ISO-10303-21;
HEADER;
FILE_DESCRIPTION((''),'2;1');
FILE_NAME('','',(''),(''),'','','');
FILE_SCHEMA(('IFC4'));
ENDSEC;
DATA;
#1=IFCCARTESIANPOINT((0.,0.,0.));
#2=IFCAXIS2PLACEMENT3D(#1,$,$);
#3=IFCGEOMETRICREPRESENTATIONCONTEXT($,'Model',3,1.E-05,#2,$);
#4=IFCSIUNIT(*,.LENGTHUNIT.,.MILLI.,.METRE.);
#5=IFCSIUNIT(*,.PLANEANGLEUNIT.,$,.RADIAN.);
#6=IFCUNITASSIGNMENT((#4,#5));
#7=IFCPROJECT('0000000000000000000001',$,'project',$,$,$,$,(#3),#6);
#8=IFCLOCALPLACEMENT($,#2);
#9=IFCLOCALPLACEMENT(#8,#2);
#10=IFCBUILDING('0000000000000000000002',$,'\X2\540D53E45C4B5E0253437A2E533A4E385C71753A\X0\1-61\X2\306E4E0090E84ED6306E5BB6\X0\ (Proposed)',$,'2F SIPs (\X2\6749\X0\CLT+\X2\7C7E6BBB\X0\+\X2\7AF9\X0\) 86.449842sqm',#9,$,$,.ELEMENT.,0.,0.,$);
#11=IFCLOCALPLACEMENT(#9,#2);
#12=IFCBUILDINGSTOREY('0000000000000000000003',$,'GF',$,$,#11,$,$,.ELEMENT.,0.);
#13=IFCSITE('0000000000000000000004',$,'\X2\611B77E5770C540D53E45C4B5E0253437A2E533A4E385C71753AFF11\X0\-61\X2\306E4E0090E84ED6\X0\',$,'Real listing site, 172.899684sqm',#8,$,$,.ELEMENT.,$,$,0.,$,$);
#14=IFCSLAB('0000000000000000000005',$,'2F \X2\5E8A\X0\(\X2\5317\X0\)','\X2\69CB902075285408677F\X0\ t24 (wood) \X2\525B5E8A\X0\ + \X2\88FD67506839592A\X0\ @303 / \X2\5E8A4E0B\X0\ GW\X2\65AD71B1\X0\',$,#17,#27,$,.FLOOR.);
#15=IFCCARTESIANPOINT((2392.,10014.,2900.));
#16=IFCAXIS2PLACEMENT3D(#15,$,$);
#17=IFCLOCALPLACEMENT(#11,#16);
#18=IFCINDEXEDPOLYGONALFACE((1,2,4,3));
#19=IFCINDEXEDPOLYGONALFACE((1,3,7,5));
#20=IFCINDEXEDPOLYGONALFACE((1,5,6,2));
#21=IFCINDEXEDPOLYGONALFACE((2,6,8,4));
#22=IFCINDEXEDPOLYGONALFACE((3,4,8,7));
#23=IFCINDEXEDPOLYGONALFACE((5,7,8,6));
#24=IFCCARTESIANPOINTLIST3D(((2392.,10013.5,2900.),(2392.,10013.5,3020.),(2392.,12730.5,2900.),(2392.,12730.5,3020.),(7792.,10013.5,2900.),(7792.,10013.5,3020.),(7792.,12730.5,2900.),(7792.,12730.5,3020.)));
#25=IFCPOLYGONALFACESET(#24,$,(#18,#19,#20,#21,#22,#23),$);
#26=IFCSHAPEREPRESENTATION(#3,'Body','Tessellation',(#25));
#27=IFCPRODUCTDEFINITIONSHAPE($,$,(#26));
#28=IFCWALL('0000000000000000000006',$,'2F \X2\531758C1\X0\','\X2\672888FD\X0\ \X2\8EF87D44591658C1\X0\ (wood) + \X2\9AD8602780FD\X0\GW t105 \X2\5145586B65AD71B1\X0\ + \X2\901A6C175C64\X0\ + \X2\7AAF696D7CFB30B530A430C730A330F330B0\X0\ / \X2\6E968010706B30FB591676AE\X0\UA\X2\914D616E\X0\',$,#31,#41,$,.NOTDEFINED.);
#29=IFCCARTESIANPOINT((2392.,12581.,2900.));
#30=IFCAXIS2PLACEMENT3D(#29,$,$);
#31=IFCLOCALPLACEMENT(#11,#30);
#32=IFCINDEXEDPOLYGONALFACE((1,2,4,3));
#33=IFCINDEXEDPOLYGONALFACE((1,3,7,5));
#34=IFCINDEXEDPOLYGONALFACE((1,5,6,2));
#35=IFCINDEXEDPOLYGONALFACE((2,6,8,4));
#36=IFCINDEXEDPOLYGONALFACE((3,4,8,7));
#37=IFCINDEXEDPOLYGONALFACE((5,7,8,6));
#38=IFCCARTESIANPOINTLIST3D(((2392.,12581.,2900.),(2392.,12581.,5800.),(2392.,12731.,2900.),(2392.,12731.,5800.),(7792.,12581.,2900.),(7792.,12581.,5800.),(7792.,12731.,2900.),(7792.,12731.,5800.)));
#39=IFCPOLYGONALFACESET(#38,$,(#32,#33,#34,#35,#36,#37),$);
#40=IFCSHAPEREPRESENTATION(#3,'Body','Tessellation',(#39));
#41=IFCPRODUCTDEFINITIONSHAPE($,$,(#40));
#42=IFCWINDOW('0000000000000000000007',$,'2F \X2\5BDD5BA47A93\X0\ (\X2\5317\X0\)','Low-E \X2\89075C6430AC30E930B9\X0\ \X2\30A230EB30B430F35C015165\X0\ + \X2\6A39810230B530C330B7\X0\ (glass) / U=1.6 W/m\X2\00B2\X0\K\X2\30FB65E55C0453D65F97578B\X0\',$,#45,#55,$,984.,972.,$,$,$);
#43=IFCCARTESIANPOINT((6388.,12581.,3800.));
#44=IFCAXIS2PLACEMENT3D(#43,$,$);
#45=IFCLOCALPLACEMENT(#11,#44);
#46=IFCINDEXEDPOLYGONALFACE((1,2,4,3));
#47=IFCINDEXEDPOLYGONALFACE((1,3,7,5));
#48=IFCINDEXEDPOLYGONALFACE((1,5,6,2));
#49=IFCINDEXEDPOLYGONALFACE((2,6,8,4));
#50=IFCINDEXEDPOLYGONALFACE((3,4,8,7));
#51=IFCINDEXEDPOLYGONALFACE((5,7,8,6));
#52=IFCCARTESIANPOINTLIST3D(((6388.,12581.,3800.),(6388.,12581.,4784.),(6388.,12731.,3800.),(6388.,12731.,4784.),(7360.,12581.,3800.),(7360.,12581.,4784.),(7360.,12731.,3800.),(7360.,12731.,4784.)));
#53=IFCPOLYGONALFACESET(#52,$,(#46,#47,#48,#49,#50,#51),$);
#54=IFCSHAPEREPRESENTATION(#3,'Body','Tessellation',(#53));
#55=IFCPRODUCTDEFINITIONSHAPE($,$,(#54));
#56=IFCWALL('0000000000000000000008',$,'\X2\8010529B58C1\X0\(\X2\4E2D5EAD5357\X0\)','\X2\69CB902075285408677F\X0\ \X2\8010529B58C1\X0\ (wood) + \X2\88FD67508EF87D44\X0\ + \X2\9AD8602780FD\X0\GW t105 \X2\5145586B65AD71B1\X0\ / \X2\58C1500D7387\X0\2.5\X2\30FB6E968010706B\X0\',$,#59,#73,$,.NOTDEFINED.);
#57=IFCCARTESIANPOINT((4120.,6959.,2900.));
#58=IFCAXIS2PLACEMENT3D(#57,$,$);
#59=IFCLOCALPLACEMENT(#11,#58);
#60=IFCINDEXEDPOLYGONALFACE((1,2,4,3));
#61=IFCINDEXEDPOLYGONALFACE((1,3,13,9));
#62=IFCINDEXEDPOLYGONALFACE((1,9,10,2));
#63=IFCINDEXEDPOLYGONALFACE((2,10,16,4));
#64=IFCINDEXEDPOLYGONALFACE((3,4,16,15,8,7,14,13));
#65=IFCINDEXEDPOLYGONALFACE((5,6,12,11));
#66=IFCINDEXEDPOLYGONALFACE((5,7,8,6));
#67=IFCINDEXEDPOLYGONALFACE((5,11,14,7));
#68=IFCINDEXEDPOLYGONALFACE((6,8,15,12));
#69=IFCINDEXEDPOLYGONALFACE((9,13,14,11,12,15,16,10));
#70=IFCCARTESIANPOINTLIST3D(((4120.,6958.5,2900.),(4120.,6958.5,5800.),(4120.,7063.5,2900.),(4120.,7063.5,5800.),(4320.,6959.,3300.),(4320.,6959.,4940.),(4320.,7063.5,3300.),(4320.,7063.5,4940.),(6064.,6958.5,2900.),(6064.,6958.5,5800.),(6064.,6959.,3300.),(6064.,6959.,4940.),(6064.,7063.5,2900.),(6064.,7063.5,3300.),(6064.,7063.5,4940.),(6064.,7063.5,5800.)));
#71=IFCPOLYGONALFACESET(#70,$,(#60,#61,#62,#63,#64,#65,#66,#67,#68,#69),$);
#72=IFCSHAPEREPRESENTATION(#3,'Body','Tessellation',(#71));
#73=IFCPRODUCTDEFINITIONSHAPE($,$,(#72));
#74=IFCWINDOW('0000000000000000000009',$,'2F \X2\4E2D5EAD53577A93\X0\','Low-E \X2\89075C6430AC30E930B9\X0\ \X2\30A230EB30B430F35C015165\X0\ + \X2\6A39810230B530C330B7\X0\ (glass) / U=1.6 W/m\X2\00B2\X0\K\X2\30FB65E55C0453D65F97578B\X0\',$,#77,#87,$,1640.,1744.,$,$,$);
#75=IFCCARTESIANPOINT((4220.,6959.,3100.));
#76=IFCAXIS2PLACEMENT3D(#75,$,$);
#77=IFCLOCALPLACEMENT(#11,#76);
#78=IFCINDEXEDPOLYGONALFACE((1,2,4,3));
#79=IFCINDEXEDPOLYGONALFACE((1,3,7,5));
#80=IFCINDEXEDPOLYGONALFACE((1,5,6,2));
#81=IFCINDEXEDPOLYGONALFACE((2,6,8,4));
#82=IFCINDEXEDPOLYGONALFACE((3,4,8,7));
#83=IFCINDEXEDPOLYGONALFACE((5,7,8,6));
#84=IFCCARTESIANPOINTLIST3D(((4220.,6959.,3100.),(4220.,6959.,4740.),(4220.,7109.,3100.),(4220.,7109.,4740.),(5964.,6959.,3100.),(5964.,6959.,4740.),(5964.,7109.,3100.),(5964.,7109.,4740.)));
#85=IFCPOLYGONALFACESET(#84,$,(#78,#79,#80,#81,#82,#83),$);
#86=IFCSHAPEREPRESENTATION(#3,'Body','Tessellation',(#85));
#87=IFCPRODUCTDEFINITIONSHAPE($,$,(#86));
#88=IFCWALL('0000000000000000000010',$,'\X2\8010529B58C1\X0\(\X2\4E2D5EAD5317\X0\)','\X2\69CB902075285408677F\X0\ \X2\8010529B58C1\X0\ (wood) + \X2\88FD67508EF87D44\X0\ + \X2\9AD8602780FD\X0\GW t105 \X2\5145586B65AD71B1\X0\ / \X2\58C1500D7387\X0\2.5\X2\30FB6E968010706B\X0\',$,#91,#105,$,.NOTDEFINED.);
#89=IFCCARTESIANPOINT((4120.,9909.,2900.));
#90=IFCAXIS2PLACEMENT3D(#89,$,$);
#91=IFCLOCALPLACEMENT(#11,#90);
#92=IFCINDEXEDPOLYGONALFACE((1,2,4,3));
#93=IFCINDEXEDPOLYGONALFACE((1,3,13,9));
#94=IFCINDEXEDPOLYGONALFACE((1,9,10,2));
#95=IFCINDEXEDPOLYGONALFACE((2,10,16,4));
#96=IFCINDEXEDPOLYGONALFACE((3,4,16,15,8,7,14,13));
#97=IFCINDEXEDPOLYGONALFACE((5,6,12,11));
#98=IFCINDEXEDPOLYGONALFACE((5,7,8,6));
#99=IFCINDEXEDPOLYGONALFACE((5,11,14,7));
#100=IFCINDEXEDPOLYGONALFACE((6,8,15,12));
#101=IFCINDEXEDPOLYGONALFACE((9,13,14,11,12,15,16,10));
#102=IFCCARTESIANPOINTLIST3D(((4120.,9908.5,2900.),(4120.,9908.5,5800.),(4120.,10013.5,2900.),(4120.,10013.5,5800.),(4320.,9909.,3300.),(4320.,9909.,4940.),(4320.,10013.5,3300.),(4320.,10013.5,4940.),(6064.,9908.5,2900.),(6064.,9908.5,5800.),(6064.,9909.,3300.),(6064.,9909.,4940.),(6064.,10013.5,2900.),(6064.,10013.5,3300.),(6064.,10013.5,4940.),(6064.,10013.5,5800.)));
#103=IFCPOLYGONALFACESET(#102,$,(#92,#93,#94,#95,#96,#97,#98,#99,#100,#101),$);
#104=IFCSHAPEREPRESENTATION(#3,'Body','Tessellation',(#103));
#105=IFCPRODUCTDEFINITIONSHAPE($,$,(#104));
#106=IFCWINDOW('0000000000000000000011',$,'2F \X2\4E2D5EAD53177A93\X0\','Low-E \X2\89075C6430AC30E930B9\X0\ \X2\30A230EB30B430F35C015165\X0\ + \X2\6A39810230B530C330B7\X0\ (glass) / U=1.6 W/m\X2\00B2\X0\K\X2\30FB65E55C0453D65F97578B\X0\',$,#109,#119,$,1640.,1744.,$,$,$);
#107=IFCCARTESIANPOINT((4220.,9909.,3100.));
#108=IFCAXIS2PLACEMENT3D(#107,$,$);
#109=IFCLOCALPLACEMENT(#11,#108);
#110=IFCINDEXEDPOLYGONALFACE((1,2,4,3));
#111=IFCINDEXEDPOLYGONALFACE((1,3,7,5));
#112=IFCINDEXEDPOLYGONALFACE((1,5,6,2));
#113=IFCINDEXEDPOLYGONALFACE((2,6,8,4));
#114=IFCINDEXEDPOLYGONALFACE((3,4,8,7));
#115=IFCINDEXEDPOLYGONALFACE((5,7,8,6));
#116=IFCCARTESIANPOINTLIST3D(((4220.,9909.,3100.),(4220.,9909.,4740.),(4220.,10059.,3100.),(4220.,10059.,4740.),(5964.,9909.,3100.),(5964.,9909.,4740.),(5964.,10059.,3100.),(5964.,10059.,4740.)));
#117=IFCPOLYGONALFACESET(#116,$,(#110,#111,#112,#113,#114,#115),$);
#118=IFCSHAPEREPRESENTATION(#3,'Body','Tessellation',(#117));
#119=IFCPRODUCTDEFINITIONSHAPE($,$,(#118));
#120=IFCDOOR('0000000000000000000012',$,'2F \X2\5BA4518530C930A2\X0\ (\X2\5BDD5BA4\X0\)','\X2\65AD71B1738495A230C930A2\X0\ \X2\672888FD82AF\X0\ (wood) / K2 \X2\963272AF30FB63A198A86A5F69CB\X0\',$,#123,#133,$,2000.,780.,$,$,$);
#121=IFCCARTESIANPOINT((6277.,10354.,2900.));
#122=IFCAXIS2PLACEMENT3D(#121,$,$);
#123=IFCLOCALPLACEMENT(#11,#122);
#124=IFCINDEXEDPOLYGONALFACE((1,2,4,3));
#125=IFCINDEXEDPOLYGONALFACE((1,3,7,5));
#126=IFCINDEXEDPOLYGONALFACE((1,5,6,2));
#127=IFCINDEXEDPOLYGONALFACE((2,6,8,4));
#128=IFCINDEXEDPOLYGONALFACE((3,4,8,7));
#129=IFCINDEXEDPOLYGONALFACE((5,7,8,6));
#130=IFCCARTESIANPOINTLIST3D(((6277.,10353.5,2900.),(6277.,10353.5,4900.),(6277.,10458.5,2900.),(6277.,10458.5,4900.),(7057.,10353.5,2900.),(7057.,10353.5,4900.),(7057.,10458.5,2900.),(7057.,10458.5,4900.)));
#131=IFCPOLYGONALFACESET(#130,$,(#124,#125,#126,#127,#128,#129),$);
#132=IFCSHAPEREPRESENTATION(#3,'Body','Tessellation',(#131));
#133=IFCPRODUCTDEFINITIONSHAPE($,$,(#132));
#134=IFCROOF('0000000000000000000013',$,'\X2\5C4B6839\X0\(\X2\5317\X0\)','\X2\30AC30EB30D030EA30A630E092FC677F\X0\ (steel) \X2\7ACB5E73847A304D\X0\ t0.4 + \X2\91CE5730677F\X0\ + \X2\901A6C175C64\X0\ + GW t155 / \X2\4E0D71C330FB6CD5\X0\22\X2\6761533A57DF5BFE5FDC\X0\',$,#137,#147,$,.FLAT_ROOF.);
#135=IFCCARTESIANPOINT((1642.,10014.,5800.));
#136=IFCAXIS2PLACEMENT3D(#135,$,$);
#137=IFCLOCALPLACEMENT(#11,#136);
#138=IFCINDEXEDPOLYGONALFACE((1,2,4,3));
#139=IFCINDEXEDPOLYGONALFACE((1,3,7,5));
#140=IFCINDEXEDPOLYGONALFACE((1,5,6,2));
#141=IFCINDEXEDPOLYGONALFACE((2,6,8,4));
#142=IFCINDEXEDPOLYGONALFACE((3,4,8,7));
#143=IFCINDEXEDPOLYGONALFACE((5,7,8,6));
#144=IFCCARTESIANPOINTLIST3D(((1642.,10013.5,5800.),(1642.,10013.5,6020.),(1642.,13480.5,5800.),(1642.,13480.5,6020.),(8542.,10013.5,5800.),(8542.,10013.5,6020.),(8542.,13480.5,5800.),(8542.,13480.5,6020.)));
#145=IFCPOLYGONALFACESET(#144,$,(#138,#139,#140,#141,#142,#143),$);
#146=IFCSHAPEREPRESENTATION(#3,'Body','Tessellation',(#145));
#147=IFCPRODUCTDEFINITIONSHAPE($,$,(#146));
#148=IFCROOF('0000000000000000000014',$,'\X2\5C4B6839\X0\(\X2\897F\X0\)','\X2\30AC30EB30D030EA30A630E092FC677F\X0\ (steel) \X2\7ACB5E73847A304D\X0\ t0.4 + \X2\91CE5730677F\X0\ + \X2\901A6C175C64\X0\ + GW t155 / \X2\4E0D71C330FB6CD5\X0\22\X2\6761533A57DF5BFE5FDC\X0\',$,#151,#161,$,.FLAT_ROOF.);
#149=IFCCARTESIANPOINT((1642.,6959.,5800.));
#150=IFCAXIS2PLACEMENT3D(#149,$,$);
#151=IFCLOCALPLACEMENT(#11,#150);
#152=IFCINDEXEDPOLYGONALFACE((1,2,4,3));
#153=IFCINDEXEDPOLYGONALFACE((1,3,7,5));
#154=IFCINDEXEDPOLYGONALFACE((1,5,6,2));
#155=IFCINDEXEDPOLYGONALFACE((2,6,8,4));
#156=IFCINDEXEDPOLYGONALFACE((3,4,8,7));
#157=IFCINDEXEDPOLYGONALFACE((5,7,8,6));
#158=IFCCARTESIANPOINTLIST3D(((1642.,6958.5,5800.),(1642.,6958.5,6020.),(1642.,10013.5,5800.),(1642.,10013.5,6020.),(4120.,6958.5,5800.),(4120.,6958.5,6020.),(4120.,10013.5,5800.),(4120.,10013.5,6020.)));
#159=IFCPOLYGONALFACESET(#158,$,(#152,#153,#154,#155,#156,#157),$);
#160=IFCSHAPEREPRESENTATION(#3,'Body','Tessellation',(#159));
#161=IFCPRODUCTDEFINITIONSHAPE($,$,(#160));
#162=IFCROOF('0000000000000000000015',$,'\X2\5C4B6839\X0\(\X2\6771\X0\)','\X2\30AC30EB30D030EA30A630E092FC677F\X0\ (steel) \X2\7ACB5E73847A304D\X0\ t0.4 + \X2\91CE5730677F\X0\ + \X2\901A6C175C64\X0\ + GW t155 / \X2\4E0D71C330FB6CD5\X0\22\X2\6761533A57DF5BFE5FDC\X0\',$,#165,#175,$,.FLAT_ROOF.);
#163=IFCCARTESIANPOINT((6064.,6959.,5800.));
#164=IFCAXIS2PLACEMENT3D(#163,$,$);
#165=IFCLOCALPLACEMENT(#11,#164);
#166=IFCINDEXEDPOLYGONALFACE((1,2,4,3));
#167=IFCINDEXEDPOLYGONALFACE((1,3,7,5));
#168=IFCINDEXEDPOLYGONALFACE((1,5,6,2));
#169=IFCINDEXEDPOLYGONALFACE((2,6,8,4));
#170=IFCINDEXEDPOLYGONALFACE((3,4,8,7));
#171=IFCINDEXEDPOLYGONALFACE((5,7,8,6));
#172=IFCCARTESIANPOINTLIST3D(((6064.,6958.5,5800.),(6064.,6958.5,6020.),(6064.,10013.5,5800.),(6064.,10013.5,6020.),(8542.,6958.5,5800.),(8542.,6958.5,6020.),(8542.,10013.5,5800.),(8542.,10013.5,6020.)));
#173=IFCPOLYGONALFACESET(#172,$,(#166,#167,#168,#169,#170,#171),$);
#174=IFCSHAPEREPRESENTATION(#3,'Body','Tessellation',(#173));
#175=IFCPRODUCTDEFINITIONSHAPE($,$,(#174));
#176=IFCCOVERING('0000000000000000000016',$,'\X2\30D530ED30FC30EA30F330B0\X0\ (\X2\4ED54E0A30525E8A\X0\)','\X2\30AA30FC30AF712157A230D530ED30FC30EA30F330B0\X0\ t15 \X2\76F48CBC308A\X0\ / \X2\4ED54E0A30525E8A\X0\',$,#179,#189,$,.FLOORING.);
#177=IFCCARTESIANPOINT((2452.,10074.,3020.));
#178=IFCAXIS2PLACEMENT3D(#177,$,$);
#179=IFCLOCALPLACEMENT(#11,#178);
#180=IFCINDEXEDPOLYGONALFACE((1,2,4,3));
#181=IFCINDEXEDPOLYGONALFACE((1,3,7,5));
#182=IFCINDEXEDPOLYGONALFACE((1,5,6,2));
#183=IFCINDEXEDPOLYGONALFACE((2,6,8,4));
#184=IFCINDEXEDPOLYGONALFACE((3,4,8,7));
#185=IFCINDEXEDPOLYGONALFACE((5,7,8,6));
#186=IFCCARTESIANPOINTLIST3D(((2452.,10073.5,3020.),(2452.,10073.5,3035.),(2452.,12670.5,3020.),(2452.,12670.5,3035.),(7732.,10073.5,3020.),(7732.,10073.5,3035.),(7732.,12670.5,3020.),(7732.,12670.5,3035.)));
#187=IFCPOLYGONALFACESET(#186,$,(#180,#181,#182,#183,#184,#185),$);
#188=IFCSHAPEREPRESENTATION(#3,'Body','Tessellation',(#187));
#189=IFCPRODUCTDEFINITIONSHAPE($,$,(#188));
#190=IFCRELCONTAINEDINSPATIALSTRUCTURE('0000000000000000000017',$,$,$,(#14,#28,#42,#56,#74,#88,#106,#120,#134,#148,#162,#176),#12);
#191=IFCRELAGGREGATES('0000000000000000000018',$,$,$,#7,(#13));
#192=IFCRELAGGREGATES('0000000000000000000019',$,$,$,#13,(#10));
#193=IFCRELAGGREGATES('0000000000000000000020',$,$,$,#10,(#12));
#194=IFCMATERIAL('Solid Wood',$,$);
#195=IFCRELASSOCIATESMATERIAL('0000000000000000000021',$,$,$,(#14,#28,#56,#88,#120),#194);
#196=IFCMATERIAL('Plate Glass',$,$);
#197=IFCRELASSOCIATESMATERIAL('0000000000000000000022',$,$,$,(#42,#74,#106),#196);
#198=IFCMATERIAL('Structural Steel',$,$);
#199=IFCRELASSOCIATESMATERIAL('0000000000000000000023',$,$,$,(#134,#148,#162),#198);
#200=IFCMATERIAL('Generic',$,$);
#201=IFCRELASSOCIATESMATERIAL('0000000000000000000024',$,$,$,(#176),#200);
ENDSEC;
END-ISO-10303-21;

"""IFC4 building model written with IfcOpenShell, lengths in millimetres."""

from ifc_helpers import new_model, si_unit, frame, frame_2d, origin, place, context, project, spatial, rectangle, extrude, material, element, fill, save


model = new_model("IFC4")

# Units and contexts
model_context = context("Model", 3, precision=1e-05, world=origin())
ifc_project = project(units=[si_unit("LENGTHUNIT", "METRE", prefix="MILLI"), si_unit("PLANEANGLEUNIT", "RADIAN")], contexts=[model_context])

# Site, building, storey
site_placement = place(None, origin())
site = spatial("IfcSite", under=ifc_project, at=site_placement, Name="愛知県名古屋市千種区丸山町１-61の一部他", ObjectType="Real listing site, 172.899684sqm", CompositionType="ELEMENT", RefElevation=0.0)
building_placement = place(site_placement, origin())
building = spatial("IfcBuilding", under=site, at=building_placement, Name="名古屋市千種区丸山町1-61の一部他の家 (Proposed)", ObjectType="2F SIPs (杉CLT+籾殻+竹) 86.449842sqm", CompositionType="ELEMENT", ElevationOfRefHeight=0.0, ElevationOfTerrain=0.0)
storey_placement = place(building_placement, origin())
storey = spatial("IfcBuildingStorey", under=building, at=storey_placement, Name="GF", CompositionType="ELEMENT", Elevation=0.0)

# Slab
ifc_material_1 = material(Name="Solid Wood")
slab_placement = place(storey_placement, frame((2392.0, 10014.0, 2900.0)))
element("IfcSlab", 1, at=slab_placement, inside=storey, material=ifc_material_1, Name="2F 床(北)", Description="構造用合板 t24 (wood) 剛床 + 製材根太 @303 / 床下 GW断熱", PredefinedType="FLOOR", context=model_context, shape_type="SweptSolid", body=[
    extrude(rectangle(XDim=5400.0, YDim=2717.0, at=frame_2d((2700.0, 1358.0))), frame((2392.0, 10014.0, 2900.0)), (0.0, 0.0, 1.0), 120.0),
])

# Walls, openings, windows
wall_1_placement = place(storey_placement, frame((2392.0, 12581.0, 2900.0)))
wall_1 = element("IfcWall", 2, at=wall_1_placement, inside=storey, material=ifc_material_1, Name="2F 北壁", Description="木製 軸組外壁 (wood) + 高性能GW t105 充填断熱 + 通気層 + 窯業系サイディング / 準耐火・外皮UA配慮", PredefinedType="NOTDEFINED", context=model_context, shape_type="SweptSolid", body=[
    extrude(rectangle(XDim=5400.0, YDim=150.0, at=frame_2d((2700.0, 75.0))), frame((2392.0, 12581.0, 2900.0)), (0.0, 0.0, 1.0), 2900.0),
])
opening_1_placement = place(storey_placement, frame((6388.0, 12581.0, 3800.0)))
opening_1 = element("IfcOpeningElement", 3, at=opening_1_placement, cuts=wall_1, PredefinedType="NOTDEFINED", context=model_context, shape_type="SweptSolid", body=[
    extrude(rectangle(XDim=972.0, YDim=150.0, at=frame_2d((486.0, 75.0))), frame((6388.0, 12581.0, 3800.0)), (0.0, 0.0, 1.0), 984.0),
])
ifc_material_2 = material(Name="Plate Glass")
window_1_placement = place(storey_placement, frame((6388.0, 12581.0, 3800.0)))
window_1 = element("IfcWindow", 4, at=window_1_placement, inside=storey, material=ifc_material_2, Name="2F 寝室窓 (北)", Description="Low-E 複層ガラス アルゴン封入 + 樹脂サッシ (glass) / U=1.6 W/m²K・日射取得型", OverallHeight=984.0, OverallWidth=972.0, context=model_context, shape_type="SweptSolid", body=[
    extrude(rectangle(XDim=972.0, YDim=150.0, at=frame_2d((486.0, 75.0))), frame((6388.0, 12581.0, 3800.0)), (0.0, 0.0, 1.0), 984.0),
])
fill(opening_1, window_1)
wall_2_placement = place(storey_placement, frame((4120.0, 6959.0, 2900.0)))
wall_2 = element("IfcWall", 5, at=wall_2_placement, inside=storey, material=ifc_material_1, Name="耐力壁(中庭南)", Description="構造用合板 耐力壁 (wood) + 製材軸組 + 高性能GW t105 充填断熱 / 壁倍率2.5・準耐火", PredefinedType="NOTDEFINED", context=model_context, shape_type="SweptSolid", body=[
    extrude(rectangle(XDim=1944.0, YDim=105.0, at=frame_2d((972.0, 52.0))), frame((4120.0, 6959.0, 2900.0)), (0.0, 0.0, 1.0), 2900.0),
])
opening_2_placement = place(storey_placement, frame((4220.0, 6959.0, 3100.0)))
opening_2 = element("IfcOpeningElement", 6, at=opening_2_placement, cuts=wall_2, PredefinedType="NOTDEFINED", context=model_context, shape_type="SweptSolid", body=[
    extrude(rectangle(XDim=1744.0, YDim=150.0, at=frame_2d((872.0, 75.0))), frame((4220.0, 6959.0, 3100.0)), (0.0, 0.0, 1.0), 1640.0),
])
window_2_placement = place(storey_placement, frame((4220.0, 6959.0, 3100.0)))
window_2 = element("IfcWindow", 7, at=window_2_placement, inside=storey, material=ifc_material_2, Name="2F 中庭南窓", Description="Low-E 複層ガラス アルゴン封入 + 樹脂サッシ (glass) / U=1.6 W/m²K・日射取得型", OverallHeight=1640.0, OverallWidth=1744.0, context=model_context, shape_type="SweptSolid", body=[
    extrude(rectangle(XDim=1744.0, YDim=150.0, at=frame_2d((872.0, 75.0))), frame((4220.0, 6959.0, 3100.0)), (0.0, 0.0, 1.0), 1640.0),
])
fill(opening_2, window_2)
wall_3_placement = place(storey_placement, frame((4120.0, 9909.0, 2900.0)))
wall_3 = element("IfcWall", 8, at=wall_3_placement, inside=storey, material=ifc_material_1, Name="耐力壁(中庭北)", Description="構造用合板 耐力壁 (wood) + 製材軸組 + 高性能GW t105 充填断熱 / 壁倍率2.5・準耐火", PredefinedType="NOTDEFINED", context=model_context, shape_type="SweptSolid", body=[
    extrude(rectangle(XDim=1944.0, YDim=105.0, at=frame_2d((972.0, 52.0))), frame((4120.0, 9909.0, 2900.0)), (0.0, 0.0, 1.0), 2900.0),
])
opening_3_placement = place(storey_placement, frame((4220.0, 9909.0, 3100.0)))
opening_3 = element("IfcOpeningElement", 9, at=opening_3_placement, cuts=wall_3, PredefinedType="NOTDEFINED", context=model_context, shape_type="SweptSolid", body=[
    extrude(rectangle(XDim=1744.0, YDim=150.0, at=frame_2d((872.0, 75.0))), frame((4220.0, 9909.0, 3100.0)), (0.0, 0.0, 1.0), 1640.0),
])
window_3_placement = place(storey_placement, frame((4220.0, 9909.0, 3100.0)))
window_3 = element("IfcWindow", 10, at=window_3_placement, inside=storey, material=ifc_material_2, Name="2F 中庭北窓", Description="Low-E 複層ガラス アルゴン封入 + 樹脂サッシ (glass) / U=1.6 W/m²K・日射取得型", OverallHeight=1640.0, OverallWidth=1744.0, context=model_context, shape_type="SweptSolid", body=[
    extrude(rectangle(XDim=1744.0, YDim=150.0, at=frame_2d((872.0, 75.0))), frame((4220.0, 9909.0, 3100.0)), (0.0, 0.0, 1.0), 1640.0),
])
fill(opening_3, window_3)

# Door
door_placement = place(storey_placement, frame((6277.0, 10354.0, 2900.0)))
element("IfcDoor", 11, at=door_placement, inside=storey, material=ifc_material_1, Name="2F 室内ドア (寝室)", Description="断熱玄関ドア 木製芯 (wood) / K2 防犯・採風機構", OverallHeight=2000.0, OverallWidth=780.0, context=model_context, shape_type="SweptSolid", body=[
    extrude(rectangle(XDim=780.0, YDim=105.0, at=frame_2d((390.0, 52.0))), frame((6277.0, 10354.0, 2900.0)), (0.0, 0.0, 1.0), 2000.0),
])

# Roofs
ifc_material_3 = material(Name="Structural Steel")
for number, where, name in (
    (12, (1642.0, 10014.0, 5800.0), "屋根(北)"),
):
    element("IfcRoof", number, at=place(storey_placement, frame(where)), inside=storey, material=ifc_material_3, Name=name, Description="ガルバリウム鋼板 (steel) 立平葺き t0.4 + 野地板 + 通気層 + GW t155 / 不燃・法22条区域対応", PredefinedType="FLAT_ROOF", context=model_context, shape_type="SweptSolid", body=[
        extrude(rectangle(XDim=6900.0, YDim=3467.0, at=frame_2d((3450.0, 1733.0))), frame((1642.0, 10014.0, 5800.0)), (0.0, 0.0, 1.0), 220.0),
    ])
roof_1_placement = place(storey_placement, frame((1642.0, 6959.0, 5800.0)))
element("IfcRoof", 13, at=roof_1_placement, inside=storey, material=ifc_material_3, Name="屋根(西)", Description="ガルバリウム鋼板 (steel) 立平葺き t0.4 + 野地板 + 通気層 + GW t155 / 不燃・法22条区域対応", PredefinedType="FLAT_ROOF", context=model_context, shape_type="SweptSolid", body=[
    extrude(rectangle(XDim=2478.0, YDim=3055.0, at=frame_2d((1239.0, 1527.0))), frame((1642.0, 6959.0, 5800.0)), (0.0, 0.0, 1.0), 220.0),
])
roof_2_placement = place(storey_placement, frame((6064.0, 6959.0, 5800.0)))
element("IfcRoof", 14, at=roof_2_placement, inside=storey, material=ifc_material_3, Name="屋根(東)", Description="ガルバリウム鋼板 (steel) 立平葺き t0.4 + 野地板 + 通気層 + GW t155 / 不燃・法22条区域対応", PredefinedType="FLAT_ROOF", context=model_context, shape_type="SweptSolid", body=[
    extrude(rectangle(XDim=2478.0, YDim=3055.0, at=frame_2d((1239.0, 1527.0))), frame((6064.0, 6959.0, 5800.0)), (0.0, 0.0, 1.0), 220.0),
])

# Covering
ifc_material_4 = material(Name="Generic")
covering_1_placement = place(storey_placement, frame((2452.0, 10074.0, 3020.0)))
element("IfcCovering", 15, at=covering_1_placement, inside=storey, material=ifc_material_4, Name="フローリング (仕上げ床)", Description="オーク無垢フローリング t15 直貼り / 仕上げ床", PredefinedType="FLOORING", context=model_context, shape_type="SweptSolid", body=[
    extrude(rectangle(XDim=5280.0, YDim=2597.0, at=frame_2d((2640.0, 1298.0))), frame((2452.0, 10074.0, 3020.0)), (0.0, 0.0, 1.0), 15.0),
])

save(model, "model.ifc")
